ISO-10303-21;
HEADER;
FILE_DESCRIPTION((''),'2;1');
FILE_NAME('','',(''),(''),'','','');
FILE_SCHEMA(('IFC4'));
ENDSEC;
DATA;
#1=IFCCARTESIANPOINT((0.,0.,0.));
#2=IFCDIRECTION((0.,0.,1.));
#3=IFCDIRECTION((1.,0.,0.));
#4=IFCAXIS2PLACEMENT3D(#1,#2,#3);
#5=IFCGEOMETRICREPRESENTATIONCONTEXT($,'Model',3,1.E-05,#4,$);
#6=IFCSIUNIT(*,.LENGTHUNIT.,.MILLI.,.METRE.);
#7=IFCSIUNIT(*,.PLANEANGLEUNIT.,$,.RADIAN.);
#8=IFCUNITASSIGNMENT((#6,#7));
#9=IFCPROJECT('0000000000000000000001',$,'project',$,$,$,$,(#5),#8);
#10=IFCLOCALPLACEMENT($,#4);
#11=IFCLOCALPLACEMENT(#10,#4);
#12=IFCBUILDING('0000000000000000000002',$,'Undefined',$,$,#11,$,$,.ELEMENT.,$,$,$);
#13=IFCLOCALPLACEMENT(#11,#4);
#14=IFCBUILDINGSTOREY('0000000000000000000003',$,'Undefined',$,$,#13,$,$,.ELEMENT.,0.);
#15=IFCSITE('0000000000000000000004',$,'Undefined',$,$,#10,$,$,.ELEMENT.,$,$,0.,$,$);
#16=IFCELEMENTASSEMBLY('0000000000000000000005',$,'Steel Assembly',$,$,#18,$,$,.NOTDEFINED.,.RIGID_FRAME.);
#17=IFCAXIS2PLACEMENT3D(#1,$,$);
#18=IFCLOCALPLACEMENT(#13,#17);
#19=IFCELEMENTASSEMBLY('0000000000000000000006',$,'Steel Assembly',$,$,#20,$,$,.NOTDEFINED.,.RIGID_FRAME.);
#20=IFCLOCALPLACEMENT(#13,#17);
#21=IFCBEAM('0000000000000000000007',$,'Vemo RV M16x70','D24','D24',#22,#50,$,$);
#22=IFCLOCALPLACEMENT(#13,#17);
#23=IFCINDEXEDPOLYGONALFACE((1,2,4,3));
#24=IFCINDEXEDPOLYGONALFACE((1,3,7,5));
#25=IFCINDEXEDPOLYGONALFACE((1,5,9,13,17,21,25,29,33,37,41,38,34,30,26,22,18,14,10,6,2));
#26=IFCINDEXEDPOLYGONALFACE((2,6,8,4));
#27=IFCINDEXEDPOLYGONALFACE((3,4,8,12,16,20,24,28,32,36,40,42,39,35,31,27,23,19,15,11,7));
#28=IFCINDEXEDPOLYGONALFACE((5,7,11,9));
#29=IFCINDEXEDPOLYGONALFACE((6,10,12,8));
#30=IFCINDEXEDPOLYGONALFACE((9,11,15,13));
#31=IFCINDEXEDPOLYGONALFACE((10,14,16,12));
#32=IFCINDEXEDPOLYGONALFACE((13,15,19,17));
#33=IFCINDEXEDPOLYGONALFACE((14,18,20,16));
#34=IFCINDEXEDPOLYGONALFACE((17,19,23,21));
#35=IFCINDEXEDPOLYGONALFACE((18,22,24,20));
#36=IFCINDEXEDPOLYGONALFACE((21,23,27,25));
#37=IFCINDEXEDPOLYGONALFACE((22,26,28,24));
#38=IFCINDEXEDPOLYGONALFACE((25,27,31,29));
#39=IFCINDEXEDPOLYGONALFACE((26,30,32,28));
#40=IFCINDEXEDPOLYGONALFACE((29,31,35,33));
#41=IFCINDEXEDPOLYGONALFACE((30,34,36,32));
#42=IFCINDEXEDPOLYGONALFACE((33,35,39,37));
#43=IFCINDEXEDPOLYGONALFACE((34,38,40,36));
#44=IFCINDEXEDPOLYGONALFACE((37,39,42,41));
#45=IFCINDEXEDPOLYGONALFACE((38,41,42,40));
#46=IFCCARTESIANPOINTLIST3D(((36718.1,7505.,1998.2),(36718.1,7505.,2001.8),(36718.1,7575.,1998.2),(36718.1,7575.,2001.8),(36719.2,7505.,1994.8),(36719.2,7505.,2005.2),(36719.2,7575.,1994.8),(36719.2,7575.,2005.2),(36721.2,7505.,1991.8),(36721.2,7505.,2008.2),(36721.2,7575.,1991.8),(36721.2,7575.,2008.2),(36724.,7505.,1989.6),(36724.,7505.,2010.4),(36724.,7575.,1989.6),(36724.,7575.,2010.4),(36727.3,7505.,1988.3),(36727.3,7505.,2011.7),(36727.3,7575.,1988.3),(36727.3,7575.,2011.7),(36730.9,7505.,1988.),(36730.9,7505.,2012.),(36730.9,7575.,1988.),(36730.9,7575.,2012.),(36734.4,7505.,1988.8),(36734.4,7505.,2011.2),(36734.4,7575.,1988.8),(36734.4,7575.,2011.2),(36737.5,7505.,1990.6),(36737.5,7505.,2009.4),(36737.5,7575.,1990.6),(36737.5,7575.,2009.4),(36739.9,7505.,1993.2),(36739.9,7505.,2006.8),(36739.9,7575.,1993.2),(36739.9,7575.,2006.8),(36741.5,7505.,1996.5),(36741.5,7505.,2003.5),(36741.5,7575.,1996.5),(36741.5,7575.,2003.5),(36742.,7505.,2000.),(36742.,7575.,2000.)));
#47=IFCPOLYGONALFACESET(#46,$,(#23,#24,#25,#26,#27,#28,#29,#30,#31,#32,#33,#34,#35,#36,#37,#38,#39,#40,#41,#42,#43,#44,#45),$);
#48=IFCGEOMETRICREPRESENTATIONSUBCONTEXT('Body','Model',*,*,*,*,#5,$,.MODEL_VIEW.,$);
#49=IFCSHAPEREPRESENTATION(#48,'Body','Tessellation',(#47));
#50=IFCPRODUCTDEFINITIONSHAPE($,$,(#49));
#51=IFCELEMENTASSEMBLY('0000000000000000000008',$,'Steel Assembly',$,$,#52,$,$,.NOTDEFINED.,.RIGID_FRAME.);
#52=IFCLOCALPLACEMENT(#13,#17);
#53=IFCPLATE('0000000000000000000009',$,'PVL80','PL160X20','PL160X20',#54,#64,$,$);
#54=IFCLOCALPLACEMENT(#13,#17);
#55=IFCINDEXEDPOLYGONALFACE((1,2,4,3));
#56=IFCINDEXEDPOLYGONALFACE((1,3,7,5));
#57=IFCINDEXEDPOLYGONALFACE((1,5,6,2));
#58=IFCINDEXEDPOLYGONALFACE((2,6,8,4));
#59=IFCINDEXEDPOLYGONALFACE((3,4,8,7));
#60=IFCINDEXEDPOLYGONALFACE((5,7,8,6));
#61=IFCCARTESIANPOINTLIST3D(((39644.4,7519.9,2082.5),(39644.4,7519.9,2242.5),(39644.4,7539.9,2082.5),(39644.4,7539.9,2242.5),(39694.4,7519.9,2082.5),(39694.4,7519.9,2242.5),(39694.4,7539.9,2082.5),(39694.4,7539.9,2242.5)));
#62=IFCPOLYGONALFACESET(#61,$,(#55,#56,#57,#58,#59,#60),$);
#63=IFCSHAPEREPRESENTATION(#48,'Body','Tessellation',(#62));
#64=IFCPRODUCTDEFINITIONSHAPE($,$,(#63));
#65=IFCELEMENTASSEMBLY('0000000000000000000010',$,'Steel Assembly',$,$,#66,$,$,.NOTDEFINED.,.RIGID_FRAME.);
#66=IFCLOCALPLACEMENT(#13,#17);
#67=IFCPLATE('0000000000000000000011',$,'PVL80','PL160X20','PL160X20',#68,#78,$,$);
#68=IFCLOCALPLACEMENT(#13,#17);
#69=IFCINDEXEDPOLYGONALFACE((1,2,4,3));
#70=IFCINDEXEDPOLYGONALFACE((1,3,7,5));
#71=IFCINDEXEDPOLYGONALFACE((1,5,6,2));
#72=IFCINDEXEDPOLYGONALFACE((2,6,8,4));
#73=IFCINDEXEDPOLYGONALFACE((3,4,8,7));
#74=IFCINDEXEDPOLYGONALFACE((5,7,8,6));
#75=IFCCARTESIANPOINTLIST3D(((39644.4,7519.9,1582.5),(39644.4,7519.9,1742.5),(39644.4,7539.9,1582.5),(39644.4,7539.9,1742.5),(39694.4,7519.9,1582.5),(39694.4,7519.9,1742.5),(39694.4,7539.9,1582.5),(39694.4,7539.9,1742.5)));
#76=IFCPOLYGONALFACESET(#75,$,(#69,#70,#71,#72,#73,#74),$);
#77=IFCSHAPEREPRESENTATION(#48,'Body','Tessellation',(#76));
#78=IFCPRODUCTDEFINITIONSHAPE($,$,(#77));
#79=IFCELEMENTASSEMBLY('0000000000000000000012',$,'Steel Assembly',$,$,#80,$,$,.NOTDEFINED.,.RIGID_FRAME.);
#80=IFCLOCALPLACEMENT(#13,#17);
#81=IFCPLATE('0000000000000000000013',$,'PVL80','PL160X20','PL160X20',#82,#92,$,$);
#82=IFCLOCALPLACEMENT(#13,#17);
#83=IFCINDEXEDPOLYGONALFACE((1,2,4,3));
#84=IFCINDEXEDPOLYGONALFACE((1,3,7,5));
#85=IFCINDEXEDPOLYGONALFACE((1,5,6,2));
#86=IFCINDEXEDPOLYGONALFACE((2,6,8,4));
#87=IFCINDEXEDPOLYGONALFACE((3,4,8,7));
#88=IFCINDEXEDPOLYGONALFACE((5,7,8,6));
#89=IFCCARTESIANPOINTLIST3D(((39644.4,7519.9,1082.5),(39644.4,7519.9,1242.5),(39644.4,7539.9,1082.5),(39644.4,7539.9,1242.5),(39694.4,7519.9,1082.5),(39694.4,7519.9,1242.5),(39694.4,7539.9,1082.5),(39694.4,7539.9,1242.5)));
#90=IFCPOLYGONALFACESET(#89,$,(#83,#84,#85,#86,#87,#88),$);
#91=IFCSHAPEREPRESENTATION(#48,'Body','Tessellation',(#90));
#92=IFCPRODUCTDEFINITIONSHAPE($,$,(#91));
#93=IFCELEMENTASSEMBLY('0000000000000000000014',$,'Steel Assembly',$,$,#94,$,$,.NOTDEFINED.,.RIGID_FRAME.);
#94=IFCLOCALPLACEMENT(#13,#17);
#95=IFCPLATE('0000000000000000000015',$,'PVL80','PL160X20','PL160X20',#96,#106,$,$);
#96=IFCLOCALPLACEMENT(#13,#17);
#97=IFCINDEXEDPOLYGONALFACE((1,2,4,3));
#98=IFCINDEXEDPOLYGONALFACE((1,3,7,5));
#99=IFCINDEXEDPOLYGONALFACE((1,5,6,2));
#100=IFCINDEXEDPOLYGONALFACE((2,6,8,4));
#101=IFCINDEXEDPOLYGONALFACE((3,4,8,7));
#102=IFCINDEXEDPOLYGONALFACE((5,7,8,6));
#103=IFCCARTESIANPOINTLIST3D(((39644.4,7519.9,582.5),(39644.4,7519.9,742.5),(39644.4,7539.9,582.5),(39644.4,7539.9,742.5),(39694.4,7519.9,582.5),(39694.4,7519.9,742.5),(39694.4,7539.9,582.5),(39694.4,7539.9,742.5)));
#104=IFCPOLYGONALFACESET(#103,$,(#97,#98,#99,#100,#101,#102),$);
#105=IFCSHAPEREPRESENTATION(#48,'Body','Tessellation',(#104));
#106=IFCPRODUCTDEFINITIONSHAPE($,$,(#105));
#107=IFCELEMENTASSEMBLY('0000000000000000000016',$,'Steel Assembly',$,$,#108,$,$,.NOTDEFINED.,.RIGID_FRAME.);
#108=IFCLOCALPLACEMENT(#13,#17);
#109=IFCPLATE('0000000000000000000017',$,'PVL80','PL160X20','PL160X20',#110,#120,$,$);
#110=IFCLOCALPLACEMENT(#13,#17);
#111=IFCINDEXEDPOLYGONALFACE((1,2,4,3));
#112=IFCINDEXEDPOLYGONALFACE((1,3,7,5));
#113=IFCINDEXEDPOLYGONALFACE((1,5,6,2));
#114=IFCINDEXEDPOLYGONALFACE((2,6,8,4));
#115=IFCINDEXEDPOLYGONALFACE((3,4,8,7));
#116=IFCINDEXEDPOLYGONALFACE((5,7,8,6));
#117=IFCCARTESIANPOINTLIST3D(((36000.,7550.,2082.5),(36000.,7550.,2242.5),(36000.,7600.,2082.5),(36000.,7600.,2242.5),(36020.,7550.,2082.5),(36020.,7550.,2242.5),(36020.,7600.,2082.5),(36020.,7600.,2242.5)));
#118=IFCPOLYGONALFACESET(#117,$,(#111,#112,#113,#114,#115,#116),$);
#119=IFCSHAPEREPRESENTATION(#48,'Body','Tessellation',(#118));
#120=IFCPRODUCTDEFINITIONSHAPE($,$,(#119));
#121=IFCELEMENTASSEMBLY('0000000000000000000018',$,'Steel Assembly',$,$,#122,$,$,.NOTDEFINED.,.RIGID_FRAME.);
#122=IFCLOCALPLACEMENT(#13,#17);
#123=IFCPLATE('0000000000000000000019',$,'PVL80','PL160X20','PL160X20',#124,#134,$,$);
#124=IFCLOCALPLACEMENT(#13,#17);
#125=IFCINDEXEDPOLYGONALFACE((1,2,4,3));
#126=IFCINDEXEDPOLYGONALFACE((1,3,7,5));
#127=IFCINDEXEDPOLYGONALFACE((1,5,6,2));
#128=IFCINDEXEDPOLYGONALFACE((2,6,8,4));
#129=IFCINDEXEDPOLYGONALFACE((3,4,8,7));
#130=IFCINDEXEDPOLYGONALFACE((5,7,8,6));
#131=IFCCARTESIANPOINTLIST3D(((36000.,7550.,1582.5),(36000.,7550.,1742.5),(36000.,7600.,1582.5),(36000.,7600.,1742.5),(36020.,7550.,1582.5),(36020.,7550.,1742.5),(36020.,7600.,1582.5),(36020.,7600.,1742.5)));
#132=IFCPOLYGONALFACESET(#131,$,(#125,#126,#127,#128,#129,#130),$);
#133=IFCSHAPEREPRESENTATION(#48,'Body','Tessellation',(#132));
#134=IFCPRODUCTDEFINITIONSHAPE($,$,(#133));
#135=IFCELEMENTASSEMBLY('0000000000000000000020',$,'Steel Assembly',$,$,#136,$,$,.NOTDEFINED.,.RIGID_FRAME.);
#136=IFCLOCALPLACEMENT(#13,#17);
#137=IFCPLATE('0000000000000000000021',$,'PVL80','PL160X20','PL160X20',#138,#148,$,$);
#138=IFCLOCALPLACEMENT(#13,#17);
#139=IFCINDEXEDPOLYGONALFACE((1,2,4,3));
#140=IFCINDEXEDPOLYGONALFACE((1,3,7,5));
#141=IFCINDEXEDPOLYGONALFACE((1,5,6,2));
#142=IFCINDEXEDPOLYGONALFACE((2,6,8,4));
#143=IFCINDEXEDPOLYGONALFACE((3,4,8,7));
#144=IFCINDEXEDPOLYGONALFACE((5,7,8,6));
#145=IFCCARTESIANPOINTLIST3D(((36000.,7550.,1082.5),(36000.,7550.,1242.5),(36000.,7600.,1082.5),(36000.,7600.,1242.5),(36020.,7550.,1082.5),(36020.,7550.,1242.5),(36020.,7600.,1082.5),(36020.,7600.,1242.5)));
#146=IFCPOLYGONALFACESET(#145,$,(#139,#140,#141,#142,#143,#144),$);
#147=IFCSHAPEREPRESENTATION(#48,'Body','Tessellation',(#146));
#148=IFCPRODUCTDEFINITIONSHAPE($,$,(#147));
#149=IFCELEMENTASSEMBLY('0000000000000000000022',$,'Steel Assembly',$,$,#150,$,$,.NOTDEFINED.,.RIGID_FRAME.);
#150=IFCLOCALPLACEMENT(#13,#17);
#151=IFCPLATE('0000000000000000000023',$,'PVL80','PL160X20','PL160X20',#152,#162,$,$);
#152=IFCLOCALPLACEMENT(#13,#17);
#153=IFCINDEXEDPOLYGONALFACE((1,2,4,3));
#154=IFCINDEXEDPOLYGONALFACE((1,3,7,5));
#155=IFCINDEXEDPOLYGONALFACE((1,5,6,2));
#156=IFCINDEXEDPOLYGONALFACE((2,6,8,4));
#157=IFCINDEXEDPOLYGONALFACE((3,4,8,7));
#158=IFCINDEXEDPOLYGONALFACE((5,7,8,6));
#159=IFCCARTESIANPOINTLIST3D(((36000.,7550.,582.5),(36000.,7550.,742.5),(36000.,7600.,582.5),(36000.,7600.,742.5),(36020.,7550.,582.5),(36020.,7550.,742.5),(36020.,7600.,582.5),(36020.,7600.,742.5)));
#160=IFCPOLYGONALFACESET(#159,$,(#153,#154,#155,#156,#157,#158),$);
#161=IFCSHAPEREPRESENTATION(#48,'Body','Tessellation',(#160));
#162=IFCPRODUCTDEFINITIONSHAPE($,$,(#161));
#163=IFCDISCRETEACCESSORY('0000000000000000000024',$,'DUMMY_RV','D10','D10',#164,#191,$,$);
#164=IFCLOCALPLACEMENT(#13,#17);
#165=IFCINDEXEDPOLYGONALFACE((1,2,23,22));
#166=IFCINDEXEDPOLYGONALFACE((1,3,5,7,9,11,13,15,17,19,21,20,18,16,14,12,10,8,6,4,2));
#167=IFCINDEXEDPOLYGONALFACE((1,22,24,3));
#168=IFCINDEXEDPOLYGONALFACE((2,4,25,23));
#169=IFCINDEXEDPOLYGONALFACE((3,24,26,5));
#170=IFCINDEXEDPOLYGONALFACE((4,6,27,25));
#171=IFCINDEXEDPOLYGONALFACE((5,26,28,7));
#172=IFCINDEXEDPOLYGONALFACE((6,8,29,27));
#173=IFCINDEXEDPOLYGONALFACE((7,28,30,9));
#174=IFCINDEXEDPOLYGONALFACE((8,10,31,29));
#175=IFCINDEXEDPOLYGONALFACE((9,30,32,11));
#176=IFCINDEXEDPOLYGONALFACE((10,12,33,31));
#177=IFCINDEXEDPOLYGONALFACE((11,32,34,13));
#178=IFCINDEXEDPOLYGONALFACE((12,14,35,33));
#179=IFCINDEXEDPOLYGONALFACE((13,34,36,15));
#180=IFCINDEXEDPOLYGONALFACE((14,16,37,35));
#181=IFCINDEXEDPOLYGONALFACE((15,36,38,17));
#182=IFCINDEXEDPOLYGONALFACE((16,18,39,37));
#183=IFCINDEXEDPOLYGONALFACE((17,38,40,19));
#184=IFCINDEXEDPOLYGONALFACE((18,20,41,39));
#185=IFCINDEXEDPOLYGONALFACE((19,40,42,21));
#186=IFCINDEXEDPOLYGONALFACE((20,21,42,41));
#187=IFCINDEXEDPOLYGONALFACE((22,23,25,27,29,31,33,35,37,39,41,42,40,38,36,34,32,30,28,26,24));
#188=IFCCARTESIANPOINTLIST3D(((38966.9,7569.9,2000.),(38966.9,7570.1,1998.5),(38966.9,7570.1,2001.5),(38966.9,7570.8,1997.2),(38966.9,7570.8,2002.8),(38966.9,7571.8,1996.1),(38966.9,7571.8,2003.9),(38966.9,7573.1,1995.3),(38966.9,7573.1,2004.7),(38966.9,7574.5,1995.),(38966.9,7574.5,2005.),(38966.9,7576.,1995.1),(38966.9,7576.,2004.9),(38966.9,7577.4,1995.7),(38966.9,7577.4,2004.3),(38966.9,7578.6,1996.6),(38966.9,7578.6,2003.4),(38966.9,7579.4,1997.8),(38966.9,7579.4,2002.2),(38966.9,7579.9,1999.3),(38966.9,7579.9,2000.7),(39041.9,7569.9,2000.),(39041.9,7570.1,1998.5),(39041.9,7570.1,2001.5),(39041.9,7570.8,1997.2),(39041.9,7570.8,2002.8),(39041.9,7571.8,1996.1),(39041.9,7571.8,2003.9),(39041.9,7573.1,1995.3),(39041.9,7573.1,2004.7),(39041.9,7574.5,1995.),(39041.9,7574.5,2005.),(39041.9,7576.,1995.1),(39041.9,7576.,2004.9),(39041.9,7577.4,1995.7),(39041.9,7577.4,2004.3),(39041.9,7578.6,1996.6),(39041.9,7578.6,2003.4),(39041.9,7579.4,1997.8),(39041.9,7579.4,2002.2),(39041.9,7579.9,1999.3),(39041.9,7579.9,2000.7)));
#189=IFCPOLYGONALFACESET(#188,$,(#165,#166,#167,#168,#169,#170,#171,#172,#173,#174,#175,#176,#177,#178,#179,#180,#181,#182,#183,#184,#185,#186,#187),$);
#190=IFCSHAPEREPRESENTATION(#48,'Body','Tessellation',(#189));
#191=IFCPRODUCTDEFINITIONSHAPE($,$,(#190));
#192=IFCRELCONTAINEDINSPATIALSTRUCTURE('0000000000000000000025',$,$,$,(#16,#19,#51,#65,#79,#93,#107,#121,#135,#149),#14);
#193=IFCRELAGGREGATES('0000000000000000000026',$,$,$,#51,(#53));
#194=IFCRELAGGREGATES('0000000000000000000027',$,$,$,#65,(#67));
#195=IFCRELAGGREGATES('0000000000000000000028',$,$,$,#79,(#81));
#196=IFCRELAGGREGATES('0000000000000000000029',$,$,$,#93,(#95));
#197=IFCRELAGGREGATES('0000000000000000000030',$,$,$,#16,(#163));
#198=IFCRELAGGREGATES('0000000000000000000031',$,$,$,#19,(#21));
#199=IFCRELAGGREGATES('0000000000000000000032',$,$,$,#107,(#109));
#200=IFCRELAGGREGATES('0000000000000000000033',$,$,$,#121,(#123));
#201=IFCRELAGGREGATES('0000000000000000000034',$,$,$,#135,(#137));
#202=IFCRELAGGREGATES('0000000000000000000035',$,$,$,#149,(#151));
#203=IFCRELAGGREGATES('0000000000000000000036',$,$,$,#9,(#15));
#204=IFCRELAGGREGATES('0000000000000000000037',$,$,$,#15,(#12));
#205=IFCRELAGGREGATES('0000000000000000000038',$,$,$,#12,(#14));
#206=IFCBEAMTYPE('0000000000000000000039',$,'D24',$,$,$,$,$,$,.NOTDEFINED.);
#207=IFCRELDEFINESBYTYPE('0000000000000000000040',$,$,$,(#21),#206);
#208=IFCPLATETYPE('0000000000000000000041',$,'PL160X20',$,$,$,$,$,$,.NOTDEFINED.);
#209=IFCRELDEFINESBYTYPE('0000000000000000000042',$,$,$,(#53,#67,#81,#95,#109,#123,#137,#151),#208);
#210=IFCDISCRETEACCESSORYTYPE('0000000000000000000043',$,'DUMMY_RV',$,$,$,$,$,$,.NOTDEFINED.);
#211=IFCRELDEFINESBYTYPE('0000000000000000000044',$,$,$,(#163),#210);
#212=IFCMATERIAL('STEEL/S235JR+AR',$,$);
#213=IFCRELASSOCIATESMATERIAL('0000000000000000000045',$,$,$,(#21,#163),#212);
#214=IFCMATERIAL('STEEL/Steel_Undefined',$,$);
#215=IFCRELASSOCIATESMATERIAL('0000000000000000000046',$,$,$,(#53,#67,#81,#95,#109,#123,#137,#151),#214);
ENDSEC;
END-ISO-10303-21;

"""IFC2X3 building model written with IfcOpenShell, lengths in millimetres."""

from ifc_helpers import new_model, si_unit, frame, origin_with_axes, origin_2d_with_axis, place, context, subcontext, project, spatial, polyline, circle, outline, extrude, material, type_object, element, aggregate, save


model = new_model("IFC2X3")

# Units and contexts
model_context = context("Model", 3, precision=1e-05, world=origin_with_axes())
body_context = subcontext(model_context, "Body", "Model", "MODEL_VIEW")
ifc_project = project(units=[si_unit("LENGTHUNIT", "METRE", prefix="MILLI"), si_unit("PLANEANGLEUNIT", "RADIAN")], contexts=[model_context])

# Site, building, storey
site_placement = place(None, origin_with_axes())
site = spatial("IfcSite", under=ifc_project, at=site_placement, Name="Undefined", CompositionType="ELEMENT", RefElevation=0.0)
building_placement = place(site_placement, origin_with_axes())
building = spatial("IfcBuilding", under=site, at=building_placement, Name="Undefined", CompositionType="ELEMENT")
storey_placement = place(building_placement, origin_with_axes())
storey = spatial("IfcBuildingStorey", under=building, at=storey_placement, Name="Undefined", CompositionType="ELEMENT", Elevation=0.0)

# Element assemblies, beam
assembly_1_placement = place(storey_placement, origin_with_axes())
assembly_1 = element("IfcElementAssembly", 1, at=assembly_1_placement, inside=storey, Name="Steel Assembly", AssemblyPlace="NOTDEFINED", PredefinedType="RIGID_FRAME")
ifc_material_1 = material(Name="STEEL/S235JR+AR")
beam_type_1 = type_object("IfcBeamType", Name="D24", PredefinedType="NOTDEFINED")
assembly_2_placement = place(storey_placement, origin_with_axes())
assembly_2 = element("IfcElementAssembly", 2, at=assembly_2_placement, inside=storey, Name="Steel Assembly", AssemblyPlace="NOTDEFINED", PredefinedType="RIGID_FRAME")
beam_1_placement = place(assembly_2_placement, frame((36730.0, 7505.0, 2000.0), z_axis=(0.0, 0.0, 1.0), x_axis=(0.00003, 1.0, 0.0)))
beam_1 = element("IfcBeam", 3, at=beam_1_placement, type_object=beam_type_1, material=ifc_material_1, Name="Vemo RV M16x70", Description="D24", ObjectType="D24", context=body_context, shape_type="SweptSolid", body=[
    extrude(circle(Radius=12.0, at=origin_2d_with_axis()), frame((70.0, 0.0, 0.0), z_axis=(-1.0, 0.0, 0.0), x_axis=(0.0, -1.0, 0.0)), (0.0, 0.0, 1.0), 70.0),
])

# Element assemblies, plates
assembly_3_placement = place(storey_placement, origin_with_axes())
assembly_3 = element("IfcElementAssembly", 4, at=assembly_3_placement, inside=storey, Name="Steel Assembly", AssemblyPlace="NOTDEFINED", PredefinedType="RIGID_FRAME")
ifc_material_2 = material(Name="STEEL/Steel_Undefined")
plate_type = type_object("IfcPlateType", Name="PL160X20", PredefinedType="NOTDEFINED")
plate_1_placement = place(assembly_3_placement, frame((39694.4, 7519.9, 2162.5), z_axis=(0.0, 0.0, -1.0), x_axis=(-1.0, 0.00003, 0.0)))
plate_1 = element("IfcPlate", 5, at=plate_1_placement, type_object=plate_type, material=ifc_material_2, Name="PVL80", Description="PL160X20", ObjectType="PL160X20", context=body_context, shape_type="SweptSolid", body=[
    extrude(outline(polyline([(0.0, 0.0), (50.0, 0.0), (50.0, 20.0), (0.0, 20.0), (0.0, 0.0)])), frame((0.0, 0.0, -80.0), z_axis=(0.0, 0.0, 1.0), x_axis=(1.0, 0.0, 0.0)), (0.0, 0.0, 1.0), 160.0),
])
assembly_4_placement = place(storey_placement, origin_with_axes())
assembly_4 = element("IfcElementAssembly", 6, at=assembly_4_placement, inside=storey, Name="Steel Assembly", AssemblyPlace="NOTDEFINED", PredefinedType="RIGID_FRAME")
plate_2_placement = place(assembly_4_placement, frame((39694.4, 7519.9, 1662.5), z_axis=(0.0, 0.0, -1.0), x_axis=(-1.0, 0.00003, 0.0)))
plate_2 = element("IfcPlate", 7, at=plate_2_placement, type_object=plate_type, material=ifc_material_2, Name="PVL80", Description="PL160X20", ObjectType="PL160X20", context=body_context, shape_type="SweptSolid", body=[
    extrude(outline(polyline([(0.0, 0.0), (50.0, 0.0), (50.0, 20.0), (0.0, 20.0), (0.0, 0.0)])), frame((0.0, 0.0, -80.0), z_axis=(0.0, 0.0, 1.0), x_axis=(1.0, 0.0, 0.0)), (0.0, 0.0, 1.0), 160.0),
])
assembly_5_placement = place(storey_placement, origin_with_axes())
assembly_5 = element("IfcElementAssembly", 8, at=assembly_5_placement, inside=storey, Name="Steel Assembly", AssemblyPlace="NOTDEFINED", PredefinedType="RIGID_FRAME")
plate_3_placement = place(assembly_5_placement, frame((39694.4, 7519.9, 1162.5), z_axis=(0.0, 0.0, -1.0), x_axis=(-1.0, 0.00003, 0.0)))
plate_3 = element("IfcPlate", 9, at=plate_3_placement, type_object=plate_type, material=ifc_material_2, Name="PVL80", Description="PL160X20", ObjectType="PL160X20", context=body_context, shape_type="SweptSolid", body=[
    extrude(outline(polyline([(0.0, 0.0), (50.0, 0.0), (50.0, 20.0), (0.0, 20.0), (0.0, 0.0)])), frame((0.0, 0.0, -80.0), z_axis=(0.0, 0.0, 1.0), x_axis=(1.0, 0.0, 0.0)), (0.0, 0.0, 1.0), 160.0),
])
assembly_6_placement = place(storey_placement, origin_with_axes())
assembly_6 = element("IfcElementAssembly", 10, at=assembly_6_placement, inside=storey, Name="Steel Assembly", AssemblyPlace="NOTDEFINED", PredefinedType="RIGID_FRAME")
plate_4_placement = place(assembly_6_placement, frame((39694.4, 7519.9, 662.5), z_axis=(0.0, 0.0, -1.0), x_axis=(-1.0, 0.00003, 0.0)))
plate_4 = element("IfcPlate", 11, at=plate_4_placement, type_object=plate_type, material=ifc_material_2, Name="PVL80", Description="PL160X20", ObjectType="PL160X20", context=body_context, shape_type="SweptSolid", body=[
    extrude(outline(polyline([(0.0, 0.0), (50.0, 0.0), (50.0, 20.0), (0.0, 20.0), (0.0, 0.0)])), frame((0.0, 0.0, -80.0), z_axis=(0.0, 0.0, 1.0), x_axis=(1.0, 0.0, 0.0)), (0.0, 0.0, 1.0), 160.0),
])
assembly_7_placement = place(storey_placement, origin_with_axes())
assembly_7 = element("IfcElementAssembly", 12, at=assembly_7_placement, inside=storey, Name="Steel Assembly", AssemblyPlace="NOTDEFINED", PredefinedType="RIGID_FRAME")
plate_5_placement = place(assembly_7_placement, frame((36000.0, 7550.0, 2162.5), z_axis=(0.0, 0.0, -1.0), x_axis=(0.00003, 1.0, 0.0)))
plate_5 = element("IfcPlate", 13, at=plate_5_placement, type_object=plate_type, material=ifc_material_2, Name="PVL80", Description="PL160X20", ObjectType="PL160X20", context=body_context, shape_type="SweptSolid", body=[
    extrude(outline(polyline([(0.0, 0.0), (50.0, 0.0), (50.0, 20.0), (0.0, 20.0), (0.0, 0.0)])), frame((0.0, 0.0, -80.0), z_axis=(0.0, 0.0, 1.0), x_axis=(1.0, 0.0, 0.0)), (0.0, 0.0, 1.0), 160.0),
])
assembly_8_placement = place(storey_placement, origin_with_axes())
assembly_8 = element("IfcElementAssembly", 14, at=assembly_8_placement, inside=storey, Name="Steel Assembly", AssemblyPlace="NOTDEFINED", PredefinedType="RIGID_FRAME")
plate_6_placement = place(assembly_8_placement, frame((36000.0, 7550.0, 1662.5), z_axis=(0.0, 0.0, -1.0), x_axis=(0.00003, 1.0, 0.0)))
plate_6 = element("IfcPlate", 15, at=plate_6_placement, type_object=plate_type, material=ifc_material_2, Name="PVL80", Description="PL160X20", ObjectType="PL160X20", context=body_context, shape_type="SweptSolid", body=[
    extrude(outline(polyline([(0.0, 0.0), (50.0, 0.0), (50.0, 20.0), (0.0, 20.0), (0.0, 0.0)])), frame((0.0, 0.0, -80.0), z_axis=(0.0, 0.0, 1.0), x_axis=(1.0, 0.0, 0.0)), (0.0, 0.0, 1.0), 160.0),
])
assembly_9_placement = place(storey_placement, origin_with_axes())
assembly_9 = element("IfcElementAssembly", 16, at=assembly_9_placement, inside=storey, Name="Steel Assembly", AssemblyPlace="NOTDEFINED", PredefinedType="RIGID_FRAME")
plate_7_placement = place(assembly_9_placement, frame((36000.0, 7550.0, 1162.5), z_axis=(0.0, 0.0, -1.0), x_axis=(0.00003, 1.0, 0.0)))
plate_7 = element("IfcPlate", 17, at=plate_7_placement, type_object=plate_type, material=ifc_material_2, Name="PVL80", Description="PL160X20", ObjectType="PL160X20", context=body_context, shape_type="SweptSolid", body=[
    extrude(outline(polyline([(0.0, 0.0), (50.0, 0.0), (50.0, 20.0), (0.0, 20.0), (0.0, 0.0)])), frame((0.0, 0.0, -80.0), z_axis=(0.0, 0.0, 1.0), x_axis=(1.0, 0.0, 0.0)), (0.0, 0.0, 1.0), 160.0),
])
assembly_10_placement = place(storey_placement, origin_with_axes())
assembly_10 = element("IfcElementAssembly", 18, at=assembly_10_placement, inside=storey, Name="Steel Assembly", AssemblyPlace="NOTDEFINED", PredefinedType="RIGID_FRAME")
plate_8_placement = place(assembly_10_placement, frame((36000.0, 7550.0, 662.5), z_axis=(0.0, 0.0, -1.0), x_axis=(0.00003, 1.0, 0.0)))
plate_8 = element("IfcPlate", 19, at=plate_8_placement, type_object=plate_type, material=ifc_material_2, Name="PVL80", Description="PL160X20", ObjectType="PL160X20", context=body_context, shape_type="SweptSolid", body=[
    extrude(outline(polyline([(0.0, 0.0), (50.0, 0.0), (50.0, 20.0), (0.0, 20.0), (0.0, 0.0)])), frame((0.0, 0.0, -80.0), z_axis=(0.0, 0.0, 1.0), x_axis=(1.0, 0.0, 0.0)), (0.0, 0.0, 1.0), 160.0),
])

aggregate(assembly_3, [plate_1])
aggregate(assembly_4, [plate_2])
aggregate(assembly_5, [plate_3])
aggregate(assembly_6, [plate_4])

# Discrete accessory
discrete_accessory_type = type_object("IfcDiscreteAccessoryType", Name="DUMMY_RV")
discrete_accessory_1_placement = place(assembly_1_placement, frame((38966.9, 7574.9, 2000.0), z_axis=(0.0, 0.0, 1.0), x_axis=(1.0, -0.00003, 0.0)))
discrete_accessory_1 = element("IfcDiscreteAccessory", 20, at=discrete_accessory_1_placement, type_object=discrete_accessory_type, material=ifc_material_1, Name="DUMMY_RV", Description="D10", ObjectType="D10", context=body_context, shape_type="SweptSolid", body=[
    extrude(circle(Radius=5.0, at=origin_2d_with_axis()), frame((75.0, 0.0, 0.0), z_axis=(-1.0, 0.0, 0.0), x_axis=(0.0, -1.0, 0.0)), (0.0, 0.0, 1.0), 75.0),
])
aggregate(assembly_1, [discrete_accessory_1])
aggregate(assembly_2, [beam_1])

aggregate(assembly_7, [plate_5])
aggregate(assembly_8, [plate_6])
aggregate(assembly_9, [plate_7])
aggregate(assembly_10, [plate_8])

save(model, "model.ifc")
